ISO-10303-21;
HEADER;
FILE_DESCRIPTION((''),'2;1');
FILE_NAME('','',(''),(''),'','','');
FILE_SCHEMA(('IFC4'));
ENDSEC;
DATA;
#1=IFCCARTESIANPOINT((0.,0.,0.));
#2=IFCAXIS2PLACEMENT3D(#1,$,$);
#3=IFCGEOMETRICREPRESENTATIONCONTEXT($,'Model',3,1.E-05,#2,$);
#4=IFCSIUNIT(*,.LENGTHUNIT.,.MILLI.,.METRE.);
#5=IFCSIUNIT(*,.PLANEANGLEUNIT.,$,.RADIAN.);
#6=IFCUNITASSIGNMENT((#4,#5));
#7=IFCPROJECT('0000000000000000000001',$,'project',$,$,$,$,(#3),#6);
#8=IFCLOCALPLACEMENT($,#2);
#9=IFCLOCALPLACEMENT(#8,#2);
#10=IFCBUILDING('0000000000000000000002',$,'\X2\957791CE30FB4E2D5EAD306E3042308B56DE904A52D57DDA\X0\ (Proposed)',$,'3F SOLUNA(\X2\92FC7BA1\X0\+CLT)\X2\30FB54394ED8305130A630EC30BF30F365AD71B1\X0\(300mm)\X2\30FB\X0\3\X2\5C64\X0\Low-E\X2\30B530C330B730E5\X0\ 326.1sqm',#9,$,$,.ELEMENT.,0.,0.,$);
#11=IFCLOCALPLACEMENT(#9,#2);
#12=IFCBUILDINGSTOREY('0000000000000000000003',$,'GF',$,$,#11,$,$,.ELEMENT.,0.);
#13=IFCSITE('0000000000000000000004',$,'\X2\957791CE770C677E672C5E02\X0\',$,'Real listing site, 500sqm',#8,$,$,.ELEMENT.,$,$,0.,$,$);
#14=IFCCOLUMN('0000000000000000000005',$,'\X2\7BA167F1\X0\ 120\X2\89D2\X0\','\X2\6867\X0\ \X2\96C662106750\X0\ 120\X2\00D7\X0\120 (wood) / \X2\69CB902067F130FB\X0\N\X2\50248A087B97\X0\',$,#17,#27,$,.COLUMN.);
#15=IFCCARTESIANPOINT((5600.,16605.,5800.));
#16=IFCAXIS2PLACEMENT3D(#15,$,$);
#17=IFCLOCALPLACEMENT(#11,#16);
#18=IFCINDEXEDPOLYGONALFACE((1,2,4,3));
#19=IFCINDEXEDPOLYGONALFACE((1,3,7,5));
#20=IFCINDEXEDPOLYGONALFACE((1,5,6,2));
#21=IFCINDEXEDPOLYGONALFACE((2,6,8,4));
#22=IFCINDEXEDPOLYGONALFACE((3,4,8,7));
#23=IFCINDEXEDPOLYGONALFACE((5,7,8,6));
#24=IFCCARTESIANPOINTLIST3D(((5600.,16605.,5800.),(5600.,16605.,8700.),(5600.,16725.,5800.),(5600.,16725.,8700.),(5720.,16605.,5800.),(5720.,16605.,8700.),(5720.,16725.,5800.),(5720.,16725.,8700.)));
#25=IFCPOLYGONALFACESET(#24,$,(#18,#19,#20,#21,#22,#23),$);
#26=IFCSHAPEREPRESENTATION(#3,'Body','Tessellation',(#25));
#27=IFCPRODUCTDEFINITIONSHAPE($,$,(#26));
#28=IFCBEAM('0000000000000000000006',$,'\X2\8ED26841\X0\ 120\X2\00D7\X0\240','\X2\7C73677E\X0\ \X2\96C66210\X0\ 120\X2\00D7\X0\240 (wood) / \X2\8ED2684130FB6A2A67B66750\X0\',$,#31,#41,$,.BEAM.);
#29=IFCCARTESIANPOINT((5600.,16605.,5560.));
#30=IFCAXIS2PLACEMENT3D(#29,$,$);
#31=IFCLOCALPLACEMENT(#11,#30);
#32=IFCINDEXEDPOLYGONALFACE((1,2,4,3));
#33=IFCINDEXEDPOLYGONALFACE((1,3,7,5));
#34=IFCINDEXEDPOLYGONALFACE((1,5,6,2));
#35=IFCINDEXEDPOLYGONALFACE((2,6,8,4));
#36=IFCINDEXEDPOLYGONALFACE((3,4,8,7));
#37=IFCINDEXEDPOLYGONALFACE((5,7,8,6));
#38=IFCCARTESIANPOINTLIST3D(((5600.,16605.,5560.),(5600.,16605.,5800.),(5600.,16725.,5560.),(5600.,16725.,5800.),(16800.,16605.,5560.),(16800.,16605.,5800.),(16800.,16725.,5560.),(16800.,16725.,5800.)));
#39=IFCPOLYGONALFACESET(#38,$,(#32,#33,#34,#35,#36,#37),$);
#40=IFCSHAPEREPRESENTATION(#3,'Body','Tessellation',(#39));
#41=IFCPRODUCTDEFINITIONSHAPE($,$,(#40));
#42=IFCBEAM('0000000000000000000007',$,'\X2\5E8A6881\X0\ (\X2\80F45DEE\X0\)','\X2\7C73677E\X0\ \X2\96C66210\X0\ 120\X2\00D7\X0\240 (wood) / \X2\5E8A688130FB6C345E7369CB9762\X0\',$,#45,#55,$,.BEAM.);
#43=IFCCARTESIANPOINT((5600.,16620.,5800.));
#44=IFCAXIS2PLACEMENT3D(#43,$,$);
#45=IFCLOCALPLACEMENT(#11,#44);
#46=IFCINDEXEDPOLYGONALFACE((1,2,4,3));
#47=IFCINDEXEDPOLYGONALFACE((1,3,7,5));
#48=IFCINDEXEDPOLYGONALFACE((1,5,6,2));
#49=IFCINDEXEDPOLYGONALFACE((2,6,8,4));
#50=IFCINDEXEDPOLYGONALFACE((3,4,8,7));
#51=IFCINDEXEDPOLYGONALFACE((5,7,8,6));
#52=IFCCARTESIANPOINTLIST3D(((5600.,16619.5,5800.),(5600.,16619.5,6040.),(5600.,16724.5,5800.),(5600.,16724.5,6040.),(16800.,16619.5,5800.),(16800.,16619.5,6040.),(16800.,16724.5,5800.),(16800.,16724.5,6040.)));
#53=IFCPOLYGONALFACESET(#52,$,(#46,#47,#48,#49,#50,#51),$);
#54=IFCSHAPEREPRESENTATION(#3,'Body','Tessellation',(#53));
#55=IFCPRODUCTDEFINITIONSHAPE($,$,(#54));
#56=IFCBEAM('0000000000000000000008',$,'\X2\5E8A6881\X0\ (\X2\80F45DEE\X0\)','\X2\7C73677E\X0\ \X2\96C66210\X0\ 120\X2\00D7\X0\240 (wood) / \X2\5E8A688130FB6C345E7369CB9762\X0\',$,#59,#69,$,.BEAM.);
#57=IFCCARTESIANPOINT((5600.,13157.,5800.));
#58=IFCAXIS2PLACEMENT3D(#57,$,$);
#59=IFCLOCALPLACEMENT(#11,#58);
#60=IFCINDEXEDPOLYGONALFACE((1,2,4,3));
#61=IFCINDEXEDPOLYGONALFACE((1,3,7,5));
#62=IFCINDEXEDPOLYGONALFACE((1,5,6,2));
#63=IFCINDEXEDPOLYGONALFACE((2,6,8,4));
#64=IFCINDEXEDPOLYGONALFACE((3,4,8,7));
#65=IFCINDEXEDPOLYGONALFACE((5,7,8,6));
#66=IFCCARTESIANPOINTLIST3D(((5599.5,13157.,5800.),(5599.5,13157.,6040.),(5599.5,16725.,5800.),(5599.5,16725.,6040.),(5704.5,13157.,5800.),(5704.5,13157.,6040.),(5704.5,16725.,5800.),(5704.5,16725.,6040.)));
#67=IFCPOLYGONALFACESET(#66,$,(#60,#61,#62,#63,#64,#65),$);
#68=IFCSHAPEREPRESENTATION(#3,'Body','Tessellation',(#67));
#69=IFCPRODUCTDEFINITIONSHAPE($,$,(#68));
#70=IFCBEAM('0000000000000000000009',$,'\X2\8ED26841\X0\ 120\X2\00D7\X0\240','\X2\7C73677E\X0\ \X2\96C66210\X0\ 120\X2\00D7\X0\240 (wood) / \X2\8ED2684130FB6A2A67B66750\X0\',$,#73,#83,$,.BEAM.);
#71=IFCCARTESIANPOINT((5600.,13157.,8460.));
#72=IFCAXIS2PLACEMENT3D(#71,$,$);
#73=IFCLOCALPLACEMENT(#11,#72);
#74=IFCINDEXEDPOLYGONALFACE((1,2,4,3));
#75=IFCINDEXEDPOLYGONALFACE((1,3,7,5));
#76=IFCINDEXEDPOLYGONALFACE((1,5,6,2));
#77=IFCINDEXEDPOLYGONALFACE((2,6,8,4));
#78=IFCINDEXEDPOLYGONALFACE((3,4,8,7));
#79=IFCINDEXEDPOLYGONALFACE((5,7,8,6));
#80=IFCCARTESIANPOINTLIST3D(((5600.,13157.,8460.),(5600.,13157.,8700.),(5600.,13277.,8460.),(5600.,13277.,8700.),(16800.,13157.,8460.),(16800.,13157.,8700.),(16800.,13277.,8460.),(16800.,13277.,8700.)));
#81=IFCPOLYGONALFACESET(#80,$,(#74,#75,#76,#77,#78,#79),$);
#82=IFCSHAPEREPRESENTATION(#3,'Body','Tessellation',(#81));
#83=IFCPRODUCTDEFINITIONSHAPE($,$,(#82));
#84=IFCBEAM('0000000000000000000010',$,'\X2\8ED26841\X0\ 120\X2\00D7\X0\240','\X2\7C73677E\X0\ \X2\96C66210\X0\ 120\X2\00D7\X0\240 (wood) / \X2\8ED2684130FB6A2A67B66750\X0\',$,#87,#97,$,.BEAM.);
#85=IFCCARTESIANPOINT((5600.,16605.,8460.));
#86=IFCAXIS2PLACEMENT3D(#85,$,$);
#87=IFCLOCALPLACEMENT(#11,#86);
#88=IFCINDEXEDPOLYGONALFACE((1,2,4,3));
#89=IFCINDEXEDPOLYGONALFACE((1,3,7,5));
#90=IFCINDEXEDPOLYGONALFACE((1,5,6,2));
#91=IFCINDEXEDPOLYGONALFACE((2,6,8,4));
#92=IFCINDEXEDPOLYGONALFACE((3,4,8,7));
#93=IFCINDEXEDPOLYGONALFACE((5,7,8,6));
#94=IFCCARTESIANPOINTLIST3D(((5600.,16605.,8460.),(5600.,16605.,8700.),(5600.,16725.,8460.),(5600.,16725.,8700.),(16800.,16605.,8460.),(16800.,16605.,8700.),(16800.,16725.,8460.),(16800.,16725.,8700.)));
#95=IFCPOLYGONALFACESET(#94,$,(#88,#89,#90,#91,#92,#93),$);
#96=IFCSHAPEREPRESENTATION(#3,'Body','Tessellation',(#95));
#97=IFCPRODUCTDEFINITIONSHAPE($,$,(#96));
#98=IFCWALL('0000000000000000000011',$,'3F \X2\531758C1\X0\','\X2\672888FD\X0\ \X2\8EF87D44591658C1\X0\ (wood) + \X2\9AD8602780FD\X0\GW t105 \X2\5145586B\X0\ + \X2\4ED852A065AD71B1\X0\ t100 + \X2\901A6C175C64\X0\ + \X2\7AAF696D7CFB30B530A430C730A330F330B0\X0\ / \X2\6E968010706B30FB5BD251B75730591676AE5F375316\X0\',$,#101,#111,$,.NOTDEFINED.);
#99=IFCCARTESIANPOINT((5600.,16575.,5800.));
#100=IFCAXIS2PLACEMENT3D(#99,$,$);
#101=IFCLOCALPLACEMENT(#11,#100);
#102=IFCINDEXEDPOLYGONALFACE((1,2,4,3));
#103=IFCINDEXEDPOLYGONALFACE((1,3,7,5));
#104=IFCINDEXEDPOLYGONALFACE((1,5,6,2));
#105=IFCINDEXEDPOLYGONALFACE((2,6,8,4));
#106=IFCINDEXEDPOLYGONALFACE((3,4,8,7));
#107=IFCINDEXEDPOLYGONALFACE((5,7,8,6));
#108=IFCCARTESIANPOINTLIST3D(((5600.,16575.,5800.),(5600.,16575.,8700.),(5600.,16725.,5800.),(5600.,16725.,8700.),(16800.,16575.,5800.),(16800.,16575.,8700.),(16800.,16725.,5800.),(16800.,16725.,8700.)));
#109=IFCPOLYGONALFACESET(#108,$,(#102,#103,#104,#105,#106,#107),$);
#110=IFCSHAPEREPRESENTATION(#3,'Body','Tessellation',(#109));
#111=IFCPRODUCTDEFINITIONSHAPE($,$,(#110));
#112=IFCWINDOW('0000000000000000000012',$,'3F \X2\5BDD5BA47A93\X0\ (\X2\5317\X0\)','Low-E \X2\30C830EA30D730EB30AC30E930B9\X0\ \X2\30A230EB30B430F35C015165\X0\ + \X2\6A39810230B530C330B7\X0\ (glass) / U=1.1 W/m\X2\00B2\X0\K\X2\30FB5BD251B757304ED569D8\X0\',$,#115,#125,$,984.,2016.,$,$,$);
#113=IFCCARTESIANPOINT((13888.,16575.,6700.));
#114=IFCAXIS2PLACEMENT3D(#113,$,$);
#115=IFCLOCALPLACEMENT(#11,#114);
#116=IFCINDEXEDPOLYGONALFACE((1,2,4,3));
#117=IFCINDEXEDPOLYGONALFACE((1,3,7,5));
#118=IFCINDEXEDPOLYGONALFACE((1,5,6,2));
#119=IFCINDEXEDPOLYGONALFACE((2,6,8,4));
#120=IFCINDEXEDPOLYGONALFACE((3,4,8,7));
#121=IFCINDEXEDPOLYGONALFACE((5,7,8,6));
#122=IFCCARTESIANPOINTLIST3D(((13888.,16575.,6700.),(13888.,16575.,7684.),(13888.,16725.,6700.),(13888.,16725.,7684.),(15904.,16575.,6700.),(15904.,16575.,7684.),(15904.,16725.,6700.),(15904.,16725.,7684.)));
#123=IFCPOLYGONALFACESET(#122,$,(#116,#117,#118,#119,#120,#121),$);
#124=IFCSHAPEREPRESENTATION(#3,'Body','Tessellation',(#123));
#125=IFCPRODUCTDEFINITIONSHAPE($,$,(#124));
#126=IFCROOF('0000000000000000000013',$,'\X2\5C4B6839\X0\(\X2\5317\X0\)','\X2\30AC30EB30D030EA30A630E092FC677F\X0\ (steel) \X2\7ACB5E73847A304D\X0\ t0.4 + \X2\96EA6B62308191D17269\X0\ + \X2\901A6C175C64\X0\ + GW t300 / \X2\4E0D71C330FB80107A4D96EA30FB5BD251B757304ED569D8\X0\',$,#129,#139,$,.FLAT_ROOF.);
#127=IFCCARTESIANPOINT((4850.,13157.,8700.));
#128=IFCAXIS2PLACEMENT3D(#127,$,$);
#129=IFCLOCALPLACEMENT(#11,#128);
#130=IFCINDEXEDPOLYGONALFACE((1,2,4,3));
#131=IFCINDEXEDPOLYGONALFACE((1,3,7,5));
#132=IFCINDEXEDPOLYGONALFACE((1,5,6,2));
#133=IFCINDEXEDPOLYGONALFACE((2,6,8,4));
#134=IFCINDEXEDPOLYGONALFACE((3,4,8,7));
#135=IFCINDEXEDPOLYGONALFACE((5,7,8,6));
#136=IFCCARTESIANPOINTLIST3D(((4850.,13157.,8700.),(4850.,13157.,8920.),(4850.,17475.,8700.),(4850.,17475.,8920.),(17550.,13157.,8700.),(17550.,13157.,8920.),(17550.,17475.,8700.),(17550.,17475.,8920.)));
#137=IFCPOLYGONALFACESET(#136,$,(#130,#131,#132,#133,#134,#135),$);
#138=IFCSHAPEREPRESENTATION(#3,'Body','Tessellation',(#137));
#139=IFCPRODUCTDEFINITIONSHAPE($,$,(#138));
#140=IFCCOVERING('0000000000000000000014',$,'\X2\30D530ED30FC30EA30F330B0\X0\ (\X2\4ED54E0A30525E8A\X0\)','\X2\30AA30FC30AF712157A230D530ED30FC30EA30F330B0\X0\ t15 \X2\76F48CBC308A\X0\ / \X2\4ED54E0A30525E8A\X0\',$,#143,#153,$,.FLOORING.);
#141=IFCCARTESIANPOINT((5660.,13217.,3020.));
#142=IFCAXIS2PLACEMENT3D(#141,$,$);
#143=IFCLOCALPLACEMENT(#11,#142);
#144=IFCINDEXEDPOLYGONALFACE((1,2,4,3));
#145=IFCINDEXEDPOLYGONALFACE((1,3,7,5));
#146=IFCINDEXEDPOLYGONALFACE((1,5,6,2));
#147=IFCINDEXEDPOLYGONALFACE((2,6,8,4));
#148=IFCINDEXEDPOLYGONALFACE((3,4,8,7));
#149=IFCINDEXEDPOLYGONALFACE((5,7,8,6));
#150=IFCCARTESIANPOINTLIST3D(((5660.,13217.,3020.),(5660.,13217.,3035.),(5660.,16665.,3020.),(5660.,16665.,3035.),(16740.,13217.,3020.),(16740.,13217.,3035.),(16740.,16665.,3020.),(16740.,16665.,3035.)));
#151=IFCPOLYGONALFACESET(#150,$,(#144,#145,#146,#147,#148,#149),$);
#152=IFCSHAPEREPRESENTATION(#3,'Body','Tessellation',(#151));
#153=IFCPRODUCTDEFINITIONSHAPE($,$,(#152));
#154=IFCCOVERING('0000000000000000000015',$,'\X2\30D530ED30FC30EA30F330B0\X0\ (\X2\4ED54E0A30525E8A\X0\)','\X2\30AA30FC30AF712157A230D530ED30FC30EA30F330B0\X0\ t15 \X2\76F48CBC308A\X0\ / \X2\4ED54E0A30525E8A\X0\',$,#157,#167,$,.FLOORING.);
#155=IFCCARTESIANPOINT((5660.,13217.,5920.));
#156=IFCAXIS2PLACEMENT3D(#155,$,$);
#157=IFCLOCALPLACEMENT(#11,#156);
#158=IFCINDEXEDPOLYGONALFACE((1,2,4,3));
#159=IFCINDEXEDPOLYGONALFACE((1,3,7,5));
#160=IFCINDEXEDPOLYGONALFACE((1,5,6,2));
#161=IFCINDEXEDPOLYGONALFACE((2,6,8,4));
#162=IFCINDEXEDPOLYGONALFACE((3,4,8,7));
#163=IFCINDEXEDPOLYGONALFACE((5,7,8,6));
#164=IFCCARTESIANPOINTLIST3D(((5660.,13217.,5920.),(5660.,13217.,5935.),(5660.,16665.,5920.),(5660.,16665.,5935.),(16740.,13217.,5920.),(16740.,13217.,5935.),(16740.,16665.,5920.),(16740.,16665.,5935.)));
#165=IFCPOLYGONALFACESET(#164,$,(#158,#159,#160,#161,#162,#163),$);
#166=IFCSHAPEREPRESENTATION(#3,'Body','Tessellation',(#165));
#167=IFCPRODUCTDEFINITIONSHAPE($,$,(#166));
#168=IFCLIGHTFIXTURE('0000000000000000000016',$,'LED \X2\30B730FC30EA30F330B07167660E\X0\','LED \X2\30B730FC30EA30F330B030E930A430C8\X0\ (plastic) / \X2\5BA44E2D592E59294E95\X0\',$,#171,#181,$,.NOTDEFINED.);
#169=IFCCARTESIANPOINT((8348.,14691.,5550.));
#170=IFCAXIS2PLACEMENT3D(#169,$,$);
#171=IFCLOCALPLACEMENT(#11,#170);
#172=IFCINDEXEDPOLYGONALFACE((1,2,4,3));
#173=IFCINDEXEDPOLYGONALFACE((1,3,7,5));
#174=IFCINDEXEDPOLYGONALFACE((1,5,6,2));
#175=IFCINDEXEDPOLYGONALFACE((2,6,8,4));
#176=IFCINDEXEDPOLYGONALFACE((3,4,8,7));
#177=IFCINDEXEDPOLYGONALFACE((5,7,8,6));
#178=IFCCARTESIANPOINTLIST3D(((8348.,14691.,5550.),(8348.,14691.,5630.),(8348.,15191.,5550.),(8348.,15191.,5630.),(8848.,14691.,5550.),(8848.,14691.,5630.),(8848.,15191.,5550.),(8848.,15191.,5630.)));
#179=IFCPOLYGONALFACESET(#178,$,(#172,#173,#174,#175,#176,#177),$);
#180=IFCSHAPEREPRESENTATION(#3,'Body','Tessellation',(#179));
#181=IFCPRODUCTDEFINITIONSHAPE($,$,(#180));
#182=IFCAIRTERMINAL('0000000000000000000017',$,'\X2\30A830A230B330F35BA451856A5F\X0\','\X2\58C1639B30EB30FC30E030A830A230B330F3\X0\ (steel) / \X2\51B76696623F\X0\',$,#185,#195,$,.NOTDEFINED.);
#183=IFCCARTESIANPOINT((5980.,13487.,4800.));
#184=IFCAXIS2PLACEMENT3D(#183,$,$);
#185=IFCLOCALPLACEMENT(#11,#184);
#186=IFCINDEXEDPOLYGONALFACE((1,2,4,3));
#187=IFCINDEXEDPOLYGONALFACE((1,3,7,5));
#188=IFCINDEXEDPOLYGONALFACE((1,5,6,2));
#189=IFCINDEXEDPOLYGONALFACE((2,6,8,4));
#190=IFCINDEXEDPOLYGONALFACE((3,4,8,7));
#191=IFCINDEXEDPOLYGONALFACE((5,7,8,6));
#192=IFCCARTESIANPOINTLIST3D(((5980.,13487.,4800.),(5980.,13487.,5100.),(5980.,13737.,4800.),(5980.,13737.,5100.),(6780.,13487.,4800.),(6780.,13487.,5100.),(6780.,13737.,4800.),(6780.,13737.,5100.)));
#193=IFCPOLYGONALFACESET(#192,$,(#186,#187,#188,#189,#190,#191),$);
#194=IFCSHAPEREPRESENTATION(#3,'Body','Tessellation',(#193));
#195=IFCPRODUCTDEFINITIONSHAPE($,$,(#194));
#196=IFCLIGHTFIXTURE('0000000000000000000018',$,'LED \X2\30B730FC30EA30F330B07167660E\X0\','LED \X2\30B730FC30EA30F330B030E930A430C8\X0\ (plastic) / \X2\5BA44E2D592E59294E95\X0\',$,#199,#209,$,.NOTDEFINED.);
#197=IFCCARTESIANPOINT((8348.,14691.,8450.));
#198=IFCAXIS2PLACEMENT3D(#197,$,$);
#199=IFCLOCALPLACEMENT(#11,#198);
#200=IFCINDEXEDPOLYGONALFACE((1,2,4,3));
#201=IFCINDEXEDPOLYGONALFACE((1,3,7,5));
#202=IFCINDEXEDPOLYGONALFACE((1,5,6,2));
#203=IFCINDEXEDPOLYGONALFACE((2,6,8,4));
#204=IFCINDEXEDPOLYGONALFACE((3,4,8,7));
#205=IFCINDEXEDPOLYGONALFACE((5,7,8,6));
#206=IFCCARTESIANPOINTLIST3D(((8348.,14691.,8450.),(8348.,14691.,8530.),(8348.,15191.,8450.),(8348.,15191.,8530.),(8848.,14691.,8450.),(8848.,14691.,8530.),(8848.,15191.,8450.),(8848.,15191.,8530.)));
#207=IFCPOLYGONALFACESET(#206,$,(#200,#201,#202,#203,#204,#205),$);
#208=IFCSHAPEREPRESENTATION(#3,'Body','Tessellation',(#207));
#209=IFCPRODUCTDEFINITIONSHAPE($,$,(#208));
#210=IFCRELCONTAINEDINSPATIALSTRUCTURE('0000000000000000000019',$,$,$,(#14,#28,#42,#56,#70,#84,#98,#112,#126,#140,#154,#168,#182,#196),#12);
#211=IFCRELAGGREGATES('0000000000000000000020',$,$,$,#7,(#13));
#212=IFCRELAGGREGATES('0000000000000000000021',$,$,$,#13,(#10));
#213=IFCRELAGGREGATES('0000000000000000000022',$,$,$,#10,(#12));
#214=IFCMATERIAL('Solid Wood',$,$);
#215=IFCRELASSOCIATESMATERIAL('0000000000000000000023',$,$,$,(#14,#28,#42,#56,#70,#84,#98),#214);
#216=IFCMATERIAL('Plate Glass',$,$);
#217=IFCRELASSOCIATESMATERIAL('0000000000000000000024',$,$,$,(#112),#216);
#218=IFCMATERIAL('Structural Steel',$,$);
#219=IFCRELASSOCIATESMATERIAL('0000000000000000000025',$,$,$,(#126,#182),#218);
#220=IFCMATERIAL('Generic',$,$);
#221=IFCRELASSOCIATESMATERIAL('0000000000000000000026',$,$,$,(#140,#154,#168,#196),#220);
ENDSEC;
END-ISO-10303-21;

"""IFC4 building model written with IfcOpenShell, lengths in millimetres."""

from ifc_helpers import new_model, si_unit, frame, frame_2d, origin, place, context, project, spatial, rectangle, extrude, material, element, fill, save


model = new_model("IFC4")

# Units and contexts
model_context = context("Model", 3, precision=1e-05, world=origin())
ifc_project = project(units=[si_unit("LENGTHUNIT", "METRE", prefix="MILLI"), si_unit("PLANEANGLEUNIT", "RADIAN")], contexts=[model_context])

# Site, building, storey
site_placement = place(None, origin())
site = spatial("IfcSite", under=ifc_project, at=site_placement, Name="長野県松本市", ObjectType="Real listing site, 500sqm", CompositionType="ELEMENT", RefElevation=0.0)
building_placement = place(site_placement, origin())
building = spatial("IfcBuilding", under=site, at=building_placement, Name="長野・中庭のある回遊動線 (Proposed)", ObjectType="3F SOLUNA(鋼管+CLT)・吹付けウレタン断熱(300mm)・3層Low-Eサッシュ 326.1sqm", CompositionType="ELEMENT", ElevationOfRefHeight=0.0, ElevationOfTerrain=0.0)
storey_placement = place(building_placement, origin())
storey = spatial("IfcBuildingStorey", under=building, at=storey_placement, Name="GF", CompositionType="ELEMENT", Elevation=0.0)

# Column
ifc_material_1 = material(Name="Solid Wood")
column_1_placement = place(storey_placement, frame((5600.0, 16605.0, 5800.0)))
element("IfcColumn", 1, at=column_1_placement, inside=storey, material=ifc_material_1, Name="管柱 120角", Description="桧 集成材 120×120 (wood) / 構造柱・N値計算", PredefinedType="COLUMN", context=model_context, shape_type="SweptSolid", body=[
    extrude(rectangle(XDim=120.0, YDim=120.0, at=frame_2d((60.0, 60.0))), frame((5600.0, 16605.0, 5800.0)), (0.0, 0.0, 1.0), 2900.0),
])

# Beams
beam_1_placement = place(storey_placement, frame((5600.0, 16605.0, 5560.0)))
element("IfcBeam", 2, at=beam_1_placement, inside=storey, material=ifc_material_1, Name="軒桁 120×240", Description="米松 集成 120×240 (wood) / 軒桁・横架材", PredefinedType="BEAM", context=model_context, shape_type="SweptSolid", body=[
    extrude(rectangle(XDim=11200.0, YDim=120.0, at=frame_2d((5600.0, 60.0))), frame((5600.0, 16605.0, 5560.0)), (0.0, 0.0, 1.0), 240.0),
])
beam_2_placement = place(storey_placement, frame((5600.0, 16620.0, 5800.0)))
element("IfcBeam", 3, at=beam_2_placement, inside=storey, material=ifc_material_1, Name="床梁 (胴差)", Description="米松 集成 120×240 (wood) / 床梁・水平構面", PredefinedType="BEAM", context=model_context, shape_type="SweptSolid", body=[
    extrude(rectangle(XDim=11200.0, YDim=105.0, at=frame_2d((5600.0, 52.0))), frame((5600.0, 16620.0, 5800.0)), (0.0, 0.0, 1.0), 240.0),
])
beam_3_placement = place(storey_placement, frame((5600.0, 13157.0, 5800.0)))
element("IfcBeam", 4, at=beam_3_placement, inside=storey, material=ifc_material_1, Name="床梁 (胴差)", Description="米松 集成 120×240 (wood) / 床梁・水平構面", PredefinedType="BEAM", context=model_context, shape_type="SweptSolid", body=[
    extrude(rectangle(XDim=105.0, YDim=3568.0, at=frame_2d((52.0, 1784.0))), frame((5600.0, 13157.0, 5800.0)), (0.0, 0.0, 1.0), 240.0),
])
beam_4_placement = place(storey_placement, frame((5600.0, 13157.0, 8460.0)))
element("IfcBeam", 5, at=beam_4_placement, inside=storey, material=ifc_material_1, Name="軒桁 120×240", Description="米松 集成 120×240 (wood) / 軒桁・横架材", PredefinedType="BEAM", context=model_context, shape_type="SweptSolid", body=[
    extrude(rectangle(XDim=11200.0, YDim=120.0, at=frame_2d((5600.0, 60.0))), frame((5600.0, 13157.0, 8460.0)), (0.0, 0.0, 1.0), 240.0),
])
beam_5_placement = place(storey_placement, frame((5600.0, 16605.0, 8460.0)))
element("IfcBeam", 6, at=beam_5_placement, inside=storey, material=ifc_material_1, Name="軒桁 120×240", Description="米松 集成 120×240 (wood) / 軒桁・横架材", PredefinedType="BEAM", context=model_context, shape_type="SweptSolid", body=[
    extrude(rectangle(XDim=11200.0, YDim=120.0, at=frame_2d((5600.0, 60.0))), frame((5600.0, 16605.0, 8460.0)), (0.0, 0.0, 1.0), 240.0),
])

# Wall, opening, window
wall_placement = place(storey_placement, frame((5600.0, 16575.0, 5800.0)))
wall = element("IfcWall", 7, at=wall_placement, inside=storey, material=ifc_material_1, Name="3F 北壁", Description="木製 軸組外壁 (wood) + 高性能GW t105 充填 + 付加断熱 t100 + 通気層 + 窯業系サイディング / 準耐火・寒冷地外皮強化", PredefinedType="NOTDEFINED", context=model_context, shape_type="SweptSolid", body=[
    extrude(rectangle(XDim=11200.0, YDim=150.0, at=frame_2d((5600.0, 75.0))), frame((5600.0, 16575.0, 5800.0)), (0.0, 0.0, 1.0), 2900.0),
])
opening_placement = place(storey_placement, frame((13888.0, 16575.0, 6700.0)))
opening = element("IfcOpeningElement", 8, at=opening_placement, cuts=wall, PredefinedType="NOTDEFINED", context=model_context, shape_type="SweptSolid", body=[
    extrude(rectangle(XDim=2016.0, YDim=150.0, at=frame_2d((1008.0, 75.0))), frame((13888.0, 16575.0, 6700.0)), (0.0, 0.0, 1.0), 984.0),
])
ifc_material_2 = material(Name="Plate Glass")
window_placement = place(storey_placement, frame((13888.0, 16575.0, 6700.0)))
window = element("IfcWindow", 9, at=window_placement, inside=storey, material=ifc_material_2, Name="3F 寝室窓 (北)", Description="Low-E トリプルガラス アルゴン封入 + 樹脂サッシ (glass) / U=1.1 W/m²K・寒冷地仕様", OverallHeight=984.0, OverallWidth=2016.0, context=model_context, shape_type="SweptSolid", body=[
    extrude(rectangle(XDim=2016.0, YDim=150.0, at=frame_2d((1008.0, 75.0))), frame((13888.0, 16575.0, 6700.0)), (0.0, 0.0, 1.0), 984.0),
])
fill(opening, window)

# Roof
ifc_material_3 = material(Name="Structural Steel")
for number, where, name in (
    (10, (4850.0, 13157.0, 8700.0), "屋根(北)"),
):
    element("IfcRoof", number, at=place(storey_placement, frame(where)), inside=storey, material=ifc_material_3, Name=name, Description="ガルバリウム鋼板 (steel) 立平葺き t0.4 + 雪止め金物 + 通気層 + GW t300 / 不燃・耐積雪・寒冷地仕様", PredefinedType="FLAT_ROOF", context=model_context, shape_type="SweptSolid", body=[
        extrude(rectangle(XDim=12700.0, YDim=4318.0, at=frame_2d((6350.0, 2159.0))), frame((4850.0, 13157.0, 8700.0)), (0.0, 0.0, 1.0), 220.0),
    ])

# Coverings
ifc_material_4 = material(Name="Generic")
covering_1_placement = place(storey_placement, frame((5660.0, 13217.0, 3020.0)))
element("IfcCovering", 11, at=covering_1_placement, inside=storey, material=ifc_material_4, Name="フローリング (仕上げ床)", Description="オーク無垢フローリング t15 直貼り / 仕上げ床", PredefinedType="FLOORING", context=model_context, shape_type="SweptSolid", body=[
    extrude(rectangle(XDim=11080.0, YDim=3448.0, at=frame_2d((5540.0, 1724.0))), frame((5660.0, 13217.0, 3020.0)), (0.0, 0.0, 1.0), 15.0),
])
covering_2_placement = place(storey_placement, frame((5660.0, 13217.0, 5920.0)))
element("IfcCovering", 12, at=covering_2_placement, inside=storey, material=ifc_material_4, Name="フローリング (仕上げ床)", Description="オーク無垢フローリング t15 直貼り / 仕上げ床", PredefinedType="FLOORING", context=model_context, shape_type="SweptSolid", body=[
    extrude(rectangle(XDim=11080.0, YDim=3448.0, at=frame_2d((5540.0, 1724.0))), frame((5660.0, 13217.0, 5920.0)), (0.0, 0.0, 1.0), 15.0),
])

# Light fixture
light_fixture_1_placement = place(storey_placement, frame((8348.0, 14691.0, 5550.0)))
element("IfcLightFixture", 13, at=light_fixture_1_placement, inside=storey, material=ifc_material_4, Name="LED シーリング照明", Description="LED シーリングライト (plastic) / 室中央天井", PredefinedType="NOTDEFINED", context=model_context, shape_type="SweptSolid", body=[
    extrude(rectangle(XDim=500.0, YDim=500.0, at=frame_2d((250.0, 250.0))), frame((8348.0, 14691.0, 5550.0)), (0.0, 0.0, 1.0), 80.0),
])

# Air terminal
air_terminal_1_placement = place(storey_placement, frame((5980.0, 13487.0, 4800.0)))
element("IfcAirTerminal", 14, at=air_terminal_1_placement, inside=storey, material=ifc_material_3, Name="エアコン室内機", Description="壁掛ルームエアコン (steel) / 冷暖房", PredefinedType="NOTDEFINED", context=model_context, shape_type="SweptSolid", body=[
    extrude(rectangle(XDim=800.0, YDim=250.0, at=frame_2d((400.0, 125.0))), frame((5980.0, 13487.0, 4800.0)), (0.0, 0.0, 1.0), 300.0),
])

# Light fixture
light_fixture_2_placement = place(storey_placement, frame((8348.0, 14691.0, 8450.0)))
element("IfcLightFixture", 15, at=light_fixture_2_placement, inside=storey, material=ifc_material_4, Name="LED シーリング照明", Description="LED シーリングライト (plastic) / 室中央天井", PredefinedType="NOTDEFINED", context=model_context, shape_type="SweptSolid", body=[
    extrude(rectangle(XDim=500.0, YDim=500.0, at=frame_2d((250.0, 250.0))), frame((8348.0, 14691.0, 8450.0)), (0.0, 0.0, 1.0), 80.0),
])

save(model, "model.ifc")
